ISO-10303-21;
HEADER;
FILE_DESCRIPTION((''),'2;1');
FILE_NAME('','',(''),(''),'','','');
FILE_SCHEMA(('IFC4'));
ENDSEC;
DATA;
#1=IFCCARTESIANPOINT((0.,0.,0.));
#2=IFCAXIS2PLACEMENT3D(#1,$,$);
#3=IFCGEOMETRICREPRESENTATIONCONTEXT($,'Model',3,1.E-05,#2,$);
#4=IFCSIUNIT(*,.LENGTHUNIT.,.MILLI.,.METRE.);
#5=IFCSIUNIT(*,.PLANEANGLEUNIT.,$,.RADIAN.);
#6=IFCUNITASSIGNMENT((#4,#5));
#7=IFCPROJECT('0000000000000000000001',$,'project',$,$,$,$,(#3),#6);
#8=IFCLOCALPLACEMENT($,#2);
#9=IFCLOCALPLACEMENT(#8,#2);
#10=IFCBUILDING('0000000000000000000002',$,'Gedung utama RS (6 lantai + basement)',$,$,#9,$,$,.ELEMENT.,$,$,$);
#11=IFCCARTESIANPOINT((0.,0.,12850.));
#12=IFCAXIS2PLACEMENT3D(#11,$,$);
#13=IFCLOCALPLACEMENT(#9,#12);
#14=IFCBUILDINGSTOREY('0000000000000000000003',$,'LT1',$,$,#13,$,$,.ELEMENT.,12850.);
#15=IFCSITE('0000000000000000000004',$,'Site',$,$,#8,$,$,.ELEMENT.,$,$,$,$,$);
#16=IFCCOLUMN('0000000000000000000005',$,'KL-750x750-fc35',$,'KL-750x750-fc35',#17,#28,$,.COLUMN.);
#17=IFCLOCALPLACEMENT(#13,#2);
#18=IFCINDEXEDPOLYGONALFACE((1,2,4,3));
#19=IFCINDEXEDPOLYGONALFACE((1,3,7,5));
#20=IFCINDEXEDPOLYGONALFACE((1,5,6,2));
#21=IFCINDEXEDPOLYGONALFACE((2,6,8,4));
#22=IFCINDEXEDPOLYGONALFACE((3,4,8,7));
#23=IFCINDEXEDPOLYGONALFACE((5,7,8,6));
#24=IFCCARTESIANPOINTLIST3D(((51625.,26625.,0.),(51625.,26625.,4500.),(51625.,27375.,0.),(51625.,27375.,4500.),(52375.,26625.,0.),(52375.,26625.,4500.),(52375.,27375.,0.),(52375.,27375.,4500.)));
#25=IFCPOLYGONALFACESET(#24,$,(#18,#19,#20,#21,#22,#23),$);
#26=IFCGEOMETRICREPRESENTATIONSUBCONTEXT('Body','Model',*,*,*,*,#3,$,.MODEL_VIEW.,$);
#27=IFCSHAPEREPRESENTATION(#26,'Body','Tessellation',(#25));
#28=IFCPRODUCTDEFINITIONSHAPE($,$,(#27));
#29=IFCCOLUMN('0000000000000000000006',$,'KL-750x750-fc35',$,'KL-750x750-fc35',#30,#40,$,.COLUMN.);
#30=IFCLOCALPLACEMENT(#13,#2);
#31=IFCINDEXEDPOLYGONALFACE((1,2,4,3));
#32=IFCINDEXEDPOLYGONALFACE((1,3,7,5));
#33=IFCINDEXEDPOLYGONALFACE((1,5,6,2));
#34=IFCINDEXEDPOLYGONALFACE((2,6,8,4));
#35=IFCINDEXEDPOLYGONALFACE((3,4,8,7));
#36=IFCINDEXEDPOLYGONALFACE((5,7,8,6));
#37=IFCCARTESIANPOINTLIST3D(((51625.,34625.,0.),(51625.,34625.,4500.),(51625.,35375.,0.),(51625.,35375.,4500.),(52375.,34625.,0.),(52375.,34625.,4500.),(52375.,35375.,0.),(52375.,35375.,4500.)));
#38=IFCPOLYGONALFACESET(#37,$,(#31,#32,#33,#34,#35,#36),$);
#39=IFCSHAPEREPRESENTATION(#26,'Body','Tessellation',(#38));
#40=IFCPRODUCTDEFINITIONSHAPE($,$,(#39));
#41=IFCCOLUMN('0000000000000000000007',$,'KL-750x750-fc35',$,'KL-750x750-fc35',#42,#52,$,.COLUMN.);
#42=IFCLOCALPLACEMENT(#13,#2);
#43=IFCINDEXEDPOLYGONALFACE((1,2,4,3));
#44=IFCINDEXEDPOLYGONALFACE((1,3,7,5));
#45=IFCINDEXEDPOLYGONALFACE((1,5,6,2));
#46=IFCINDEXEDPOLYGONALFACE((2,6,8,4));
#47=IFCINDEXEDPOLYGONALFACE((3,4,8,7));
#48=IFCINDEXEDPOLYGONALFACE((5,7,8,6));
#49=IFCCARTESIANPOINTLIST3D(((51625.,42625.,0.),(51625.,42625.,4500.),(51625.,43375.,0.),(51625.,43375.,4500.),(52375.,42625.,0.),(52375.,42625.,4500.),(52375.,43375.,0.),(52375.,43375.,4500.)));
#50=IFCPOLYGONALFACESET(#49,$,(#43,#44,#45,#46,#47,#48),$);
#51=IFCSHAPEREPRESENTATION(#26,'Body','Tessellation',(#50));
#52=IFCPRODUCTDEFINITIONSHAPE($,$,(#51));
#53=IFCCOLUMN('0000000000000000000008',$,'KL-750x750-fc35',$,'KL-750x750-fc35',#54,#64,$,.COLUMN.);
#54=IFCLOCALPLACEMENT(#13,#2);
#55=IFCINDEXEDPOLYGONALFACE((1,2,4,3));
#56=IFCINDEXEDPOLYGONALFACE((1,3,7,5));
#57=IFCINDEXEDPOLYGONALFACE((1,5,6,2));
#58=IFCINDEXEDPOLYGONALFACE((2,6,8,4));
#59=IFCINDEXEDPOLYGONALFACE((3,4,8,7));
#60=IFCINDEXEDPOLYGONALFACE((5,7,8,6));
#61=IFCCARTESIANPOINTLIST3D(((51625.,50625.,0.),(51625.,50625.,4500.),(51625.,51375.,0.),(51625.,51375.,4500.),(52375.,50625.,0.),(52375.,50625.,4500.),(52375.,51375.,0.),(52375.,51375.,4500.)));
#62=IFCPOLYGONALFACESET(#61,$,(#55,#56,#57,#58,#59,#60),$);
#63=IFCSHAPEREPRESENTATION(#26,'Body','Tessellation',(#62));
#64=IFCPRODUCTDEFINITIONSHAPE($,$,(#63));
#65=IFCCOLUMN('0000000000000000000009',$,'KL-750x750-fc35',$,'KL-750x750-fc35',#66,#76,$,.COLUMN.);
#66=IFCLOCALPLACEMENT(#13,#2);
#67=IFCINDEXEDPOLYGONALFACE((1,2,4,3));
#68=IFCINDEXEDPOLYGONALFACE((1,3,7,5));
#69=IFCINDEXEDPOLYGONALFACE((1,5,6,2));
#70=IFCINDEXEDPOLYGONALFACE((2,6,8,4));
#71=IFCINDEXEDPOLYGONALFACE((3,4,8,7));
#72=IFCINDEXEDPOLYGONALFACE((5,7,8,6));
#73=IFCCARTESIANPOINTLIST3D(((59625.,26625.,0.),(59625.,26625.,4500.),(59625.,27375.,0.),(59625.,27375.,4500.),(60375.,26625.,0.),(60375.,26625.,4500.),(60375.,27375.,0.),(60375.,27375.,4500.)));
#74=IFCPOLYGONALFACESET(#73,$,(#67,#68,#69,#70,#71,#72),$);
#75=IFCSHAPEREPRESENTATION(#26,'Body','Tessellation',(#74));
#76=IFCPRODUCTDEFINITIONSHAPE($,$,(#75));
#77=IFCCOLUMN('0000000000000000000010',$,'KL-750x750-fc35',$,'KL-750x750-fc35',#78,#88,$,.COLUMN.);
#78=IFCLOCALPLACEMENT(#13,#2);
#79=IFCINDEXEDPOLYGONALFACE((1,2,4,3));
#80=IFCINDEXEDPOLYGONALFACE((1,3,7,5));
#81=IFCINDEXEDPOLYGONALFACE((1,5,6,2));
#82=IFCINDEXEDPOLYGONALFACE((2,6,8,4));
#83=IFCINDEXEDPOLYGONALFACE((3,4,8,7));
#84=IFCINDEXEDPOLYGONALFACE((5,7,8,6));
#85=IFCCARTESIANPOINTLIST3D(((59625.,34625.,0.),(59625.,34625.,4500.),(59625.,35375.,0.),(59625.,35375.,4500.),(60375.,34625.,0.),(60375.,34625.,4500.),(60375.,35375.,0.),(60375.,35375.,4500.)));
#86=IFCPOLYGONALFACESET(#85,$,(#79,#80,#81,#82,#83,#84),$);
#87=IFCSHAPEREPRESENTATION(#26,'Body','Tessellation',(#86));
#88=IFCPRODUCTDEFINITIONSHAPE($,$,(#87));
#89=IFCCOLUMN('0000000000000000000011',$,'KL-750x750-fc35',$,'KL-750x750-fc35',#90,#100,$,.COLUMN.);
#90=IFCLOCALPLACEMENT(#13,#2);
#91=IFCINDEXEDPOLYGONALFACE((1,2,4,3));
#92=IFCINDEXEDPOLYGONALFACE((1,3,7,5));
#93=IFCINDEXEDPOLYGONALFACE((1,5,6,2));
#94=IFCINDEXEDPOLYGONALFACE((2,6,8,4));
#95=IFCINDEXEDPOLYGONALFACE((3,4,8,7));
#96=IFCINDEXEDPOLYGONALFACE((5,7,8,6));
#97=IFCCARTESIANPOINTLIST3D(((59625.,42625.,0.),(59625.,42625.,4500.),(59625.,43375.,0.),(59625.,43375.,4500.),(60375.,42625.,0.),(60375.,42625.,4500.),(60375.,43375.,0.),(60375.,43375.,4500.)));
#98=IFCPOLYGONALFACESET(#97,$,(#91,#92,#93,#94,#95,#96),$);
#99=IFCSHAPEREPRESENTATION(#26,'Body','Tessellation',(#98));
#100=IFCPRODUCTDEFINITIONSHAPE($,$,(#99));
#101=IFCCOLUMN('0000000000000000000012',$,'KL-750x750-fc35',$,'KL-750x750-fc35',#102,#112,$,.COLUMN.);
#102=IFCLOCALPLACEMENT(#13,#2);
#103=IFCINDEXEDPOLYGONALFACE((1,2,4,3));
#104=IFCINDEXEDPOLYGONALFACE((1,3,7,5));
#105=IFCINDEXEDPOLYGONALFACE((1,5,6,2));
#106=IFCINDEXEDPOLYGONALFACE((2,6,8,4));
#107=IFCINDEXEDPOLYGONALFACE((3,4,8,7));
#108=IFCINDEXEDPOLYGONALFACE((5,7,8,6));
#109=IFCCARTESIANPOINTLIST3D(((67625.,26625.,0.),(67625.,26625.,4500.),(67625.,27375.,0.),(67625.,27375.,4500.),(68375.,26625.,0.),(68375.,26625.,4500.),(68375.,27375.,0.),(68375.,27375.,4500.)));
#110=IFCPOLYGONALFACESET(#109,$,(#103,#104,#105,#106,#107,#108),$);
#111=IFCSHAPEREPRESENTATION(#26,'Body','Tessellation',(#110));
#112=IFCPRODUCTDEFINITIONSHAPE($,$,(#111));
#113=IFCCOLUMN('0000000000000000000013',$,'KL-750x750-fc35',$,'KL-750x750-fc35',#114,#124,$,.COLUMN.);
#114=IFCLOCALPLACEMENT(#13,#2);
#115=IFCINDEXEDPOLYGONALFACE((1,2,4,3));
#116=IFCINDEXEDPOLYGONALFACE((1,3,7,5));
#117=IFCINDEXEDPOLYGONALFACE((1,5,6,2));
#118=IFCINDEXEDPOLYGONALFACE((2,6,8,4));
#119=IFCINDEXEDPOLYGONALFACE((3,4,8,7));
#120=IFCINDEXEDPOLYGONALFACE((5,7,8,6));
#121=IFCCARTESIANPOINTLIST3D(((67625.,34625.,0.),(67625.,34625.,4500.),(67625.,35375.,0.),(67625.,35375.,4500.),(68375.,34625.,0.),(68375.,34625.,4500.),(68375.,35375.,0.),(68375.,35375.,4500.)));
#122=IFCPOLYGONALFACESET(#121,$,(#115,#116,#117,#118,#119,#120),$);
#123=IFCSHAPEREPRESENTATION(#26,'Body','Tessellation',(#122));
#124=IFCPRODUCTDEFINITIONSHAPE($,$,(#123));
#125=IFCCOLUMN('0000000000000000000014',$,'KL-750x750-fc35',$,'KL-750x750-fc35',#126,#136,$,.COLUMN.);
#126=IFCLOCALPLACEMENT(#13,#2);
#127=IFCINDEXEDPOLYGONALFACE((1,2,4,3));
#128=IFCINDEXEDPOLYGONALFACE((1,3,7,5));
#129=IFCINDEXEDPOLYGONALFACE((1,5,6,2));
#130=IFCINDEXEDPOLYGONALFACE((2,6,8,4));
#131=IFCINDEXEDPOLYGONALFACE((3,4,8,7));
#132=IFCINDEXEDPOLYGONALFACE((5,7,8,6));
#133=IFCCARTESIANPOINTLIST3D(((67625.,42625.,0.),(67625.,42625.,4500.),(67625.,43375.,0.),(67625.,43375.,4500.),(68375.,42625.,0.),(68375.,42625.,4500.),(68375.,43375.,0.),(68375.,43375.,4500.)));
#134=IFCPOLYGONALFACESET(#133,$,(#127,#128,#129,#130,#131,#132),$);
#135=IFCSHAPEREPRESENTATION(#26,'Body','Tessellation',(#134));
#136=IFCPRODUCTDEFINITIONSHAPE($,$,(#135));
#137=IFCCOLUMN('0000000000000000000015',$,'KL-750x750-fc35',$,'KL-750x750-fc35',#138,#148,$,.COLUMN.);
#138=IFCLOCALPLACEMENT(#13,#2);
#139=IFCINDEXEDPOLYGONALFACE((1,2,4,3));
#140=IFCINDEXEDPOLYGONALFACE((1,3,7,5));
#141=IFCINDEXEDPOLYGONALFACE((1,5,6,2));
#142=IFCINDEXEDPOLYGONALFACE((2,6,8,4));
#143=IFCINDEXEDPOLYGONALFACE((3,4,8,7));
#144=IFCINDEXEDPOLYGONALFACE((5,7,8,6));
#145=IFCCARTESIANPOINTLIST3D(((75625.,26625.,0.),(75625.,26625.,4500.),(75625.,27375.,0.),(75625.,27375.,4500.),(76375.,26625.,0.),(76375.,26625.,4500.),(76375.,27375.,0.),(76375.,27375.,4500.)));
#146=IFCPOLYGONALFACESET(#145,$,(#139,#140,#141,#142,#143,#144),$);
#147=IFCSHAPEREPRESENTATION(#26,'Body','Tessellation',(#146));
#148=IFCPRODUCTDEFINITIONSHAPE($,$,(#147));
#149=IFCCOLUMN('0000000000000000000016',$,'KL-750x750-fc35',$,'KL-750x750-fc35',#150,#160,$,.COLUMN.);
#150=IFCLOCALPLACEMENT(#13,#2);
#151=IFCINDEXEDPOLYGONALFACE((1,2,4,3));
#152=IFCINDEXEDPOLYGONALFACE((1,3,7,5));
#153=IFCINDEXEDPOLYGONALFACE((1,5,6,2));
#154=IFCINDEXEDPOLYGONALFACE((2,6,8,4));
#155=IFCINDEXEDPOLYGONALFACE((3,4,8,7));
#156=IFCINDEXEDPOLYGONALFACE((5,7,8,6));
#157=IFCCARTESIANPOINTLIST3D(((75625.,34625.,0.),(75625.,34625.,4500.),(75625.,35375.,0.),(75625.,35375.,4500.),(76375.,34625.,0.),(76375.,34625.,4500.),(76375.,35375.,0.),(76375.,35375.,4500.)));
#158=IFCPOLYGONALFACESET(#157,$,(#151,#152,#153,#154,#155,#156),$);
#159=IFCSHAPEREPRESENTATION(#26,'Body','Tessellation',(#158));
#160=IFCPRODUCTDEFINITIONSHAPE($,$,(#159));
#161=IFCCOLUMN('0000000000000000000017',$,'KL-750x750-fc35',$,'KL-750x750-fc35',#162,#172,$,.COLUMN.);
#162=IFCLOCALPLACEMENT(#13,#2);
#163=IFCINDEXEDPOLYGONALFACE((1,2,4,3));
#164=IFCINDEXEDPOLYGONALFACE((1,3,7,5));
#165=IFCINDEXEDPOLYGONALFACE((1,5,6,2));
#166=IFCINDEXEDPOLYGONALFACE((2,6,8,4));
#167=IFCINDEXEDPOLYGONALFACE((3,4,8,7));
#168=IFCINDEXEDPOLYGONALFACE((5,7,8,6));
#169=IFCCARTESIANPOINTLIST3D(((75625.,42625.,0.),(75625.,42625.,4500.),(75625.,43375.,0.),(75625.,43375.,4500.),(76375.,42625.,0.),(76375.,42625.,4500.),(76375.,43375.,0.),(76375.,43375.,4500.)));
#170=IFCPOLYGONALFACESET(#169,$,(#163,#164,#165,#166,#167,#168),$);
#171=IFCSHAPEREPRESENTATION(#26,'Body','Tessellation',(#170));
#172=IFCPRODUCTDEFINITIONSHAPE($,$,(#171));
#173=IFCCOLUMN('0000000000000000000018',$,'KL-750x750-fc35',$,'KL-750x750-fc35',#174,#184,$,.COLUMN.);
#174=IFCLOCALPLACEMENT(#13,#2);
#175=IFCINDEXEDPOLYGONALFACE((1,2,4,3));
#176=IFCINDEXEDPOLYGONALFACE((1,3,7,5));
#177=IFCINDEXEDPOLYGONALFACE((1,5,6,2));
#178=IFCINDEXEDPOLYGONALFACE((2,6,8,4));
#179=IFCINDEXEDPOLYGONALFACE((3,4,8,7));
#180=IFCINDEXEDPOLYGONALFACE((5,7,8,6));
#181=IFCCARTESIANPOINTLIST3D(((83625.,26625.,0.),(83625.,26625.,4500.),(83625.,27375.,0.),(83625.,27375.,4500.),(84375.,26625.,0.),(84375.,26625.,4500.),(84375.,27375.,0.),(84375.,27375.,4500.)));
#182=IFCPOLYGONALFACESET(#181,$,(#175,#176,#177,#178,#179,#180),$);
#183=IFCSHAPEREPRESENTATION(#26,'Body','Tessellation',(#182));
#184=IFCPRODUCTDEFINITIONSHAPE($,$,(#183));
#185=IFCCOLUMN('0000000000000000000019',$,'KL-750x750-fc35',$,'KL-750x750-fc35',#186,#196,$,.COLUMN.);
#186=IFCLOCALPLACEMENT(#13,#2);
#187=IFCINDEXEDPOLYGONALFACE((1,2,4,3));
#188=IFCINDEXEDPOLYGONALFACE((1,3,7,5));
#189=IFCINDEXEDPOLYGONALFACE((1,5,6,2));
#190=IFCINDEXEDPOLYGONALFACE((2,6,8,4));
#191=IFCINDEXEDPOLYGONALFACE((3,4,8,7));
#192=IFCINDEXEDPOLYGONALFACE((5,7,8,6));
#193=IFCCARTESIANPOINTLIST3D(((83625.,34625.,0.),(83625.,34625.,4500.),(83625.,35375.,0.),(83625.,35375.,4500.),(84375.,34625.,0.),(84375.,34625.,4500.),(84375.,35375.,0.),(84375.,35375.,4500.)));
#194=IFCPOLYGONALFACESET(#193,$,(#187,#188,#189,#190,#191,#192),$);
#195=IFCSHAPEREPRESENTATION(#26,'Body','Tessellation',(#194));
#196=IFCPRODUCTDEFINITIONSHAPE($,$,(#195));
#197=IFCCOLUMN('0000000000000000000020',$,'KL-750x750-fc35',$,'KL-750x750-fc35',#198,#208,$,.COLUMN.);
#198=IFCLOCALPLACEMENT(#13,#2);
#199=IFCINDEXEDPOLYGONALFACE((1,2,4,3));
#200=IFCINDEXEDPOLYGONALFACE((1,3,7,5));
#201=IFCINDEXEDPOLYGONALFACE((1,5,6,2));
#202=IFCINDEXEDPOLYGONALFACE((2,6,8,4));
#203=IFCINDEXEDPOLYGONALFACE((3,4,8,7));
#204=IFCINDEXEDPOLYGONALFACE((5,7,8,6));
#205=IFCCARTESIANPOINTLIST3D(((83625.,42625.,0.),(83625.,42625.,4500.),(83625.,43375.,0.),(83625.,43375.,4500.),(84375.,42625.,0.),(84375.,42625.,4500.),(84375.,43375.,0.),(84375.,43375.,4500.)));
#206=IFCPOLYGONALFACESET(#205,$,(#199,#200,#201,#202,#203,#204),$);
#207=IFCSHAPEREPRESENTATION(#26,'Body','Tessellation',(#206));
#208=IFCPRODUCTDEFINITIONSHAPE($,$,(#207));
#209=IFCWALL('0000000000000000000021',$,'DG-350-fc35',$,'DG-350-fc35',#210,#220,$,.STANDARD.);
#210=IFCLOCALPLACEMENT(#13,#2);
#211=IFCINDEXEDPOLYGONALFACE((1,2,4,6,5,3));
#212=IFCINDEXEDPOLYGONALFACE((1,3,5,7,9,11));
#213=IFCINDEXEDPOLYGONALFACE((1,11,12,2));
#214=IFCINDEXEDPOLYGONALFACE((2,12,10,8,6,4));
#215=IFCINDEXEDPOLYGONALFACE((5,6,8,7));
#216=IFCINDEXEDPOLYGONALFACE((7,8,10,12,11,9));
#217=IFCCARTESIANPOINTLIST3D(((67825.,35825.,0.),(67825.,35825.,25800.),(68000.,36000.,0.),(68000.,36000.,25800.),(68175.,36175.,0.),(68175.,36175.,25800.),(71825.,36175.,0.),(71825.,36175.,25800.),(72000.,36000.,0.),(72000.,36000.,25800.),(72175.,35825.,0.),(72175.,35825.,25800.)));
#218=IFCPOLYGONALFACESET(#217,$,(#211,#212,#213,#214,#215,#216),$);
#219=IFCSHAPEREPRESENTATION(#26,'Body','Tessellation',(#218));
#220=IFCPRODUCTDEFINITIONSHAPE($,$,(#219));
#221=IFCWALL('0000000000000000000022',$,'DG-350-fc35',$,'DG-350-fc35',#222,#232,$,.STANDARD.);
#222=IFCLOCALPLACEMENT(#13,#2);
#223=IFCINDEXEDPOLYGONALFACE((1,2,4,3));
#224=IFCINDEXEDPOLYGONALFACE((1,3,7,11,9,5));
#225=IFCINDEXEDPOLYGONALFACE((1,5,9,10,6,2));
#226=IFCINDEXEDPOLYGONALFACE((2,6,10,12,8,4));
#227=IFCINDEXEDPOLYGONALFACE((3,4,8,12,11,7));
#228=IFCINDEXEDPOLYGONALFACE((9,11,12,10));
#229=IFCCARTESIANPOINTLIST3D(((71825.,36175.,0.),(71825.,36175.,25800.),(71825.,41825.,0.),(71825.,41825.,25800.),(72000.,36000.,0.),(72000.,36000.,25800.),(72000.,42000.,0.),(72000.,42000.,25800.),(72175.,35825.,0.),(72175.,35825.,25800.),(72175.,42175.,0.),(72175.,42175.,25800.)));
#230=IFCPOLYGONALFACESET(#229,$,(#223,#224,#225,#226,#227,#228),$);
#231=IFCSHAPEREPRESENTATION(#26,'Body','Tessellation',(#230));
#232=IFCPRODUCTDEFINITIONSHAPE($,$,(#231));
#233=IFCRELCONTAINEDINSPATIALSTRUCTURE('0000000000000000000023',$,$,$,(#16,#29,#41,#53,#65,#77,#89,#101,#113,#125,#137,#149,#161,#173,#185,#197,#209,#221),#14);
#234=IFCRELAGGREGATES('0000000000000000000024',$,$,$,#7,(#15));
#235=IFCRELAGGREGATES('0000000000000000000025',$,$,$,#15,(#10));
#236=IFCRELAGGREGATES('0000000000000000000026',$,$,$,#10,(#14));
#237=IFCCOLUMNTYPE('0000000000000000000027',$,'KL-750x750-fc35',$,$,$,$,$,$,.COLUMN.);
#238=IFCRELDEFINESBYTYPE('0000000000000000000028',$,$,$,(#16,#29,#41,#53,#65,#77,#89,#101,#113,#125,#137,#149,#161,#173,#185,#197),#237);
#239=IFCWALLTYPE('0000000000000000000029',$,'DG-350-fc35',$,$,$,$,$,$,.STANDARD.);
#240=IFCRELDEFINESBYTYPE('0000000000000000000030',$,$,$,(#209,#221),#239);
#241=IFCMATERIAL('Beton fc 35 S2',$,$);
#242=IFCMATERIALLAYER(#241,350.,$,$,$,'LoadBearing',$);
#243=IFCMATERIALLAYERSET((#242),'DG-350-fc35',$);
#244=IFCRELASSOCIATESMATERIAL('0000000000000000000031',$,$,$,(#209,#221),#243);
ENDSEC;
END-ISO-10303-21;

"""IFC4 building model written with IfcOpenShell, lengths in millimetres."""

from ifc_helpers import new_model, si_unit, frame, origin, origin_2d, place, context, subcontext, project, spatial, polyline, rectangle, outline, extrude, material, layer, layer_set, layer_usage, material_profile, profile_set, profile_usage, type_object, element, save


model = new_model("IFC4")

# Units and contexts
model_context = context("Model", 3, precision=1e-05, world=origin())
body_context = subcontext(model_context, "Body", "Model", "MODEL_VIEW")
ifc_project = project(units=[si_unit("LENGTHUNIT", "METRE", prefix="MILLI"), si_unit("PLANEANGLEUNIT", "RADIAN")], contexts=[model_context])

# Site, building, storey
site_placement = place(None, origin())
site = spatial("IfcSite", under=ifc_project, at=site_placement, Name="Site", CompositionType="ELEMENT")
building_placement = place(site_placement, origin())
building = spatial("IfcBuilding", under=site, at=building_placement, Name="Gedung utama RS (6 lantai + basement)", CompositionType="ELEMENT")
storey_placement = place(building_placement, frame((0.0, 0.0, 12850.0)))
storey = spatial("IfcBuildingStorey", under=building, at=storey_placement, Name="LT1", CompositionType="ELEMENT", Elevation=12850.0)

# Columns
ifc_material_profile = material_profile(None, rectangle(XDim=750.0, YDim=750.0, at=origin_2d()), Name="KL-750x750-fc35")
ifc_profile_set = profile_set([ifc_material_profile], Name="KL-750x750-fc35")
ifc_profile_usage = profile_usage(ifc_profile_set, cardinal=5)
column_type = type_object("IfcColumnType", Name="KL-750x750-fc35", PredefinedType="COLUMN", material=ifc_profile_set)
for number, where, z_axis, x_axis, name in (
    (1, (52000.0, 27000.0, 0.0), (0.0, 0.0, 1.0), (1.0, 0.0, 0.0), "KL-750x750-fc35"),
    (2, (52000.0, 35000.0, 0.0), (0.0, 0.0, 1.0), (1.0, 0.0, 0.0), "KL-750x750-fc35"),
    (3, (52000.0, 43000.0, 0.0), (0.0, 0.0, 1.0), (1.0, 0.0, 0.0), "KL-750x750-fc35"),
    (4, (52000.0, 51000.0, 0.0), (0.0, 0.0, 1.0), (1.0, 0.0, 0.0), "KL-750x750-fc35"),
    (5, (60000.0, 27000.0, 0.0), (0.0, 0.0, 1.0), (1.0, 0.0, 0.0), "KL-750x750-fc35"),
    (6, (60000.0, 35000.0, 0.0), (0.0, 0.0, 1.0), (1.0, 0.0, 0.0), "KL-750x750-fc35"),
    (7, (60000.0, 43000.0, 0.0), (0.0, 0.0, 1.0), (1.0, 0.0, 0.0), "KL-750x750-fc35"),
    (8, (68000.0, 27000.0, 0.0), (0.0, 0.0, 1.0), (1.0, 0.0, 0.0), "KL-750x750-fc35"),
    (9, (68000.0, 35000.0, 0.0), (0.0, 0.0, 1.0), (1.0, 0.0, 0.0), "KL-750x750-fc35"),
    (10, (68000.0, 43000.0, 0.0), (0.0, 0.0, 1.0), (1.0, 0.0, 0.0), "KL-750x750-fc35"),
    (11, (76000.0, 27000.0, 0.0), (0.0, 0.0, 1.0), (1.0, 0.0, 0.0), "KL-750x750-fc35"),
    (12, (76000.0, 35000.0, 0.0), (0.0, 0.0, 1.0), (1.0, 0.0, 0.0), "KL-750x750-fc35"),
    (13, (76000.0, 43000.0, 0.0), (0.0, 0.0, 1.0), (1.0, 0.0, 0.0), "KL-750x750-fc35"),
    (14, (84000.0, 27000.0, 0.0), (0.0, 0.0, 1.0), (1.0, 0.0, 0.0), "KL-750x750-fc35"),
    (15, (84000.0, 35000.0, 0.0), (0.0, 0.0, 1.0), (1.0, 0.0, 0.0), "KL-750x750-fc35"),
    (16, (84000.0, 43000.0, 0.0), (0.0, 0.0, 1.0), (1.0, 0.0, 0.0), "KL-750x750-fc35"),
):
    element("IfcColumn", number, at=place(storey_placement, frame(where, z_axis=z_axis, x_axis=x_axis)), inside=storey, type_object=column_type, material=ifc_profile_usage, Name=name, ObjectType="KL-750x750-fc35", PredefinedType="COLUMN", context=body_context, shape_type="SweptSolid", body=[
        extrude(rectangle(XDim=750.0, YDim=750.0, at=origin_2d()), origin(), (0.0, 0.0, 1.0), 4500.0),
    ])

# Walls
ifc_material = material(Name="Beton fc 35 S2")
ifc_layer = layer(ifc_material, 350.0, Category="LoadBearing")
ifc_layer_set = layer_set([ifc_layer], Name="DG-350-fc35")
ifc_layer_usage = layer_usage(ifc_layer_set, "AXIS2", "NEGATIVE", 175.0)
wall_type = type_object("IfcWallType", Name="DG-350-fc35", PredefinedType="STANDARD")
wall_1_placement = place(storey_placement, frame((68000.0, 36000.0, 0.0), z_axis=(0.0, 0.0, 1.0), x_axis=(1.0, 0.0, 0.0)))
element("IfcWall", 17, at=wall_1_placement, inside=storey, type_object=wall_type, material=ifc_layer_usage, Name="DG-350-fc35", ObjectType="DG-350-fc35", PredefinedType="STANDARD", context=body_context, shape_type="SweptSolid", body=[
    extrude(outline(polyline([(-175.0, -175.0), (0.0, 0.0), (175.0, 175.0), (3825.0, 175.0), (4000.0, 0.0), (4175.0, -175.0), (-175.0, -175.0)])), origin(), (0.0, 0.0, 1.0), 25800.0),
])
wall_2_placement = place(storey_placement, frame((72000.0, 36000.0, 0.0), z_axis=(0.0, 0.0, 1.0), x_axis=(0.0, 1.0, 0.0)))
element("IfcWall", 18, at=wall_2_placement, inside=storey, type_object=wall_type, material=ifc_layer_usage, Name="DG-350-fc35", ObjectType="DG-350-fc35", PredefinedType="STANDARD", context=body_context, shape_type="SweptSolid", body=[
    extrude(outline(polyline([(-175.0, -175.0), (0.0, 0.0), (175.0, 175.0), (5825.0, 175.0), (6000.0, 0.0), (6175.0, -175.0), (-175.0, -175.0)])), origin(), (0.0, 0.0, 1.0), 25800.0),
])

save(model, "model.ifc")
